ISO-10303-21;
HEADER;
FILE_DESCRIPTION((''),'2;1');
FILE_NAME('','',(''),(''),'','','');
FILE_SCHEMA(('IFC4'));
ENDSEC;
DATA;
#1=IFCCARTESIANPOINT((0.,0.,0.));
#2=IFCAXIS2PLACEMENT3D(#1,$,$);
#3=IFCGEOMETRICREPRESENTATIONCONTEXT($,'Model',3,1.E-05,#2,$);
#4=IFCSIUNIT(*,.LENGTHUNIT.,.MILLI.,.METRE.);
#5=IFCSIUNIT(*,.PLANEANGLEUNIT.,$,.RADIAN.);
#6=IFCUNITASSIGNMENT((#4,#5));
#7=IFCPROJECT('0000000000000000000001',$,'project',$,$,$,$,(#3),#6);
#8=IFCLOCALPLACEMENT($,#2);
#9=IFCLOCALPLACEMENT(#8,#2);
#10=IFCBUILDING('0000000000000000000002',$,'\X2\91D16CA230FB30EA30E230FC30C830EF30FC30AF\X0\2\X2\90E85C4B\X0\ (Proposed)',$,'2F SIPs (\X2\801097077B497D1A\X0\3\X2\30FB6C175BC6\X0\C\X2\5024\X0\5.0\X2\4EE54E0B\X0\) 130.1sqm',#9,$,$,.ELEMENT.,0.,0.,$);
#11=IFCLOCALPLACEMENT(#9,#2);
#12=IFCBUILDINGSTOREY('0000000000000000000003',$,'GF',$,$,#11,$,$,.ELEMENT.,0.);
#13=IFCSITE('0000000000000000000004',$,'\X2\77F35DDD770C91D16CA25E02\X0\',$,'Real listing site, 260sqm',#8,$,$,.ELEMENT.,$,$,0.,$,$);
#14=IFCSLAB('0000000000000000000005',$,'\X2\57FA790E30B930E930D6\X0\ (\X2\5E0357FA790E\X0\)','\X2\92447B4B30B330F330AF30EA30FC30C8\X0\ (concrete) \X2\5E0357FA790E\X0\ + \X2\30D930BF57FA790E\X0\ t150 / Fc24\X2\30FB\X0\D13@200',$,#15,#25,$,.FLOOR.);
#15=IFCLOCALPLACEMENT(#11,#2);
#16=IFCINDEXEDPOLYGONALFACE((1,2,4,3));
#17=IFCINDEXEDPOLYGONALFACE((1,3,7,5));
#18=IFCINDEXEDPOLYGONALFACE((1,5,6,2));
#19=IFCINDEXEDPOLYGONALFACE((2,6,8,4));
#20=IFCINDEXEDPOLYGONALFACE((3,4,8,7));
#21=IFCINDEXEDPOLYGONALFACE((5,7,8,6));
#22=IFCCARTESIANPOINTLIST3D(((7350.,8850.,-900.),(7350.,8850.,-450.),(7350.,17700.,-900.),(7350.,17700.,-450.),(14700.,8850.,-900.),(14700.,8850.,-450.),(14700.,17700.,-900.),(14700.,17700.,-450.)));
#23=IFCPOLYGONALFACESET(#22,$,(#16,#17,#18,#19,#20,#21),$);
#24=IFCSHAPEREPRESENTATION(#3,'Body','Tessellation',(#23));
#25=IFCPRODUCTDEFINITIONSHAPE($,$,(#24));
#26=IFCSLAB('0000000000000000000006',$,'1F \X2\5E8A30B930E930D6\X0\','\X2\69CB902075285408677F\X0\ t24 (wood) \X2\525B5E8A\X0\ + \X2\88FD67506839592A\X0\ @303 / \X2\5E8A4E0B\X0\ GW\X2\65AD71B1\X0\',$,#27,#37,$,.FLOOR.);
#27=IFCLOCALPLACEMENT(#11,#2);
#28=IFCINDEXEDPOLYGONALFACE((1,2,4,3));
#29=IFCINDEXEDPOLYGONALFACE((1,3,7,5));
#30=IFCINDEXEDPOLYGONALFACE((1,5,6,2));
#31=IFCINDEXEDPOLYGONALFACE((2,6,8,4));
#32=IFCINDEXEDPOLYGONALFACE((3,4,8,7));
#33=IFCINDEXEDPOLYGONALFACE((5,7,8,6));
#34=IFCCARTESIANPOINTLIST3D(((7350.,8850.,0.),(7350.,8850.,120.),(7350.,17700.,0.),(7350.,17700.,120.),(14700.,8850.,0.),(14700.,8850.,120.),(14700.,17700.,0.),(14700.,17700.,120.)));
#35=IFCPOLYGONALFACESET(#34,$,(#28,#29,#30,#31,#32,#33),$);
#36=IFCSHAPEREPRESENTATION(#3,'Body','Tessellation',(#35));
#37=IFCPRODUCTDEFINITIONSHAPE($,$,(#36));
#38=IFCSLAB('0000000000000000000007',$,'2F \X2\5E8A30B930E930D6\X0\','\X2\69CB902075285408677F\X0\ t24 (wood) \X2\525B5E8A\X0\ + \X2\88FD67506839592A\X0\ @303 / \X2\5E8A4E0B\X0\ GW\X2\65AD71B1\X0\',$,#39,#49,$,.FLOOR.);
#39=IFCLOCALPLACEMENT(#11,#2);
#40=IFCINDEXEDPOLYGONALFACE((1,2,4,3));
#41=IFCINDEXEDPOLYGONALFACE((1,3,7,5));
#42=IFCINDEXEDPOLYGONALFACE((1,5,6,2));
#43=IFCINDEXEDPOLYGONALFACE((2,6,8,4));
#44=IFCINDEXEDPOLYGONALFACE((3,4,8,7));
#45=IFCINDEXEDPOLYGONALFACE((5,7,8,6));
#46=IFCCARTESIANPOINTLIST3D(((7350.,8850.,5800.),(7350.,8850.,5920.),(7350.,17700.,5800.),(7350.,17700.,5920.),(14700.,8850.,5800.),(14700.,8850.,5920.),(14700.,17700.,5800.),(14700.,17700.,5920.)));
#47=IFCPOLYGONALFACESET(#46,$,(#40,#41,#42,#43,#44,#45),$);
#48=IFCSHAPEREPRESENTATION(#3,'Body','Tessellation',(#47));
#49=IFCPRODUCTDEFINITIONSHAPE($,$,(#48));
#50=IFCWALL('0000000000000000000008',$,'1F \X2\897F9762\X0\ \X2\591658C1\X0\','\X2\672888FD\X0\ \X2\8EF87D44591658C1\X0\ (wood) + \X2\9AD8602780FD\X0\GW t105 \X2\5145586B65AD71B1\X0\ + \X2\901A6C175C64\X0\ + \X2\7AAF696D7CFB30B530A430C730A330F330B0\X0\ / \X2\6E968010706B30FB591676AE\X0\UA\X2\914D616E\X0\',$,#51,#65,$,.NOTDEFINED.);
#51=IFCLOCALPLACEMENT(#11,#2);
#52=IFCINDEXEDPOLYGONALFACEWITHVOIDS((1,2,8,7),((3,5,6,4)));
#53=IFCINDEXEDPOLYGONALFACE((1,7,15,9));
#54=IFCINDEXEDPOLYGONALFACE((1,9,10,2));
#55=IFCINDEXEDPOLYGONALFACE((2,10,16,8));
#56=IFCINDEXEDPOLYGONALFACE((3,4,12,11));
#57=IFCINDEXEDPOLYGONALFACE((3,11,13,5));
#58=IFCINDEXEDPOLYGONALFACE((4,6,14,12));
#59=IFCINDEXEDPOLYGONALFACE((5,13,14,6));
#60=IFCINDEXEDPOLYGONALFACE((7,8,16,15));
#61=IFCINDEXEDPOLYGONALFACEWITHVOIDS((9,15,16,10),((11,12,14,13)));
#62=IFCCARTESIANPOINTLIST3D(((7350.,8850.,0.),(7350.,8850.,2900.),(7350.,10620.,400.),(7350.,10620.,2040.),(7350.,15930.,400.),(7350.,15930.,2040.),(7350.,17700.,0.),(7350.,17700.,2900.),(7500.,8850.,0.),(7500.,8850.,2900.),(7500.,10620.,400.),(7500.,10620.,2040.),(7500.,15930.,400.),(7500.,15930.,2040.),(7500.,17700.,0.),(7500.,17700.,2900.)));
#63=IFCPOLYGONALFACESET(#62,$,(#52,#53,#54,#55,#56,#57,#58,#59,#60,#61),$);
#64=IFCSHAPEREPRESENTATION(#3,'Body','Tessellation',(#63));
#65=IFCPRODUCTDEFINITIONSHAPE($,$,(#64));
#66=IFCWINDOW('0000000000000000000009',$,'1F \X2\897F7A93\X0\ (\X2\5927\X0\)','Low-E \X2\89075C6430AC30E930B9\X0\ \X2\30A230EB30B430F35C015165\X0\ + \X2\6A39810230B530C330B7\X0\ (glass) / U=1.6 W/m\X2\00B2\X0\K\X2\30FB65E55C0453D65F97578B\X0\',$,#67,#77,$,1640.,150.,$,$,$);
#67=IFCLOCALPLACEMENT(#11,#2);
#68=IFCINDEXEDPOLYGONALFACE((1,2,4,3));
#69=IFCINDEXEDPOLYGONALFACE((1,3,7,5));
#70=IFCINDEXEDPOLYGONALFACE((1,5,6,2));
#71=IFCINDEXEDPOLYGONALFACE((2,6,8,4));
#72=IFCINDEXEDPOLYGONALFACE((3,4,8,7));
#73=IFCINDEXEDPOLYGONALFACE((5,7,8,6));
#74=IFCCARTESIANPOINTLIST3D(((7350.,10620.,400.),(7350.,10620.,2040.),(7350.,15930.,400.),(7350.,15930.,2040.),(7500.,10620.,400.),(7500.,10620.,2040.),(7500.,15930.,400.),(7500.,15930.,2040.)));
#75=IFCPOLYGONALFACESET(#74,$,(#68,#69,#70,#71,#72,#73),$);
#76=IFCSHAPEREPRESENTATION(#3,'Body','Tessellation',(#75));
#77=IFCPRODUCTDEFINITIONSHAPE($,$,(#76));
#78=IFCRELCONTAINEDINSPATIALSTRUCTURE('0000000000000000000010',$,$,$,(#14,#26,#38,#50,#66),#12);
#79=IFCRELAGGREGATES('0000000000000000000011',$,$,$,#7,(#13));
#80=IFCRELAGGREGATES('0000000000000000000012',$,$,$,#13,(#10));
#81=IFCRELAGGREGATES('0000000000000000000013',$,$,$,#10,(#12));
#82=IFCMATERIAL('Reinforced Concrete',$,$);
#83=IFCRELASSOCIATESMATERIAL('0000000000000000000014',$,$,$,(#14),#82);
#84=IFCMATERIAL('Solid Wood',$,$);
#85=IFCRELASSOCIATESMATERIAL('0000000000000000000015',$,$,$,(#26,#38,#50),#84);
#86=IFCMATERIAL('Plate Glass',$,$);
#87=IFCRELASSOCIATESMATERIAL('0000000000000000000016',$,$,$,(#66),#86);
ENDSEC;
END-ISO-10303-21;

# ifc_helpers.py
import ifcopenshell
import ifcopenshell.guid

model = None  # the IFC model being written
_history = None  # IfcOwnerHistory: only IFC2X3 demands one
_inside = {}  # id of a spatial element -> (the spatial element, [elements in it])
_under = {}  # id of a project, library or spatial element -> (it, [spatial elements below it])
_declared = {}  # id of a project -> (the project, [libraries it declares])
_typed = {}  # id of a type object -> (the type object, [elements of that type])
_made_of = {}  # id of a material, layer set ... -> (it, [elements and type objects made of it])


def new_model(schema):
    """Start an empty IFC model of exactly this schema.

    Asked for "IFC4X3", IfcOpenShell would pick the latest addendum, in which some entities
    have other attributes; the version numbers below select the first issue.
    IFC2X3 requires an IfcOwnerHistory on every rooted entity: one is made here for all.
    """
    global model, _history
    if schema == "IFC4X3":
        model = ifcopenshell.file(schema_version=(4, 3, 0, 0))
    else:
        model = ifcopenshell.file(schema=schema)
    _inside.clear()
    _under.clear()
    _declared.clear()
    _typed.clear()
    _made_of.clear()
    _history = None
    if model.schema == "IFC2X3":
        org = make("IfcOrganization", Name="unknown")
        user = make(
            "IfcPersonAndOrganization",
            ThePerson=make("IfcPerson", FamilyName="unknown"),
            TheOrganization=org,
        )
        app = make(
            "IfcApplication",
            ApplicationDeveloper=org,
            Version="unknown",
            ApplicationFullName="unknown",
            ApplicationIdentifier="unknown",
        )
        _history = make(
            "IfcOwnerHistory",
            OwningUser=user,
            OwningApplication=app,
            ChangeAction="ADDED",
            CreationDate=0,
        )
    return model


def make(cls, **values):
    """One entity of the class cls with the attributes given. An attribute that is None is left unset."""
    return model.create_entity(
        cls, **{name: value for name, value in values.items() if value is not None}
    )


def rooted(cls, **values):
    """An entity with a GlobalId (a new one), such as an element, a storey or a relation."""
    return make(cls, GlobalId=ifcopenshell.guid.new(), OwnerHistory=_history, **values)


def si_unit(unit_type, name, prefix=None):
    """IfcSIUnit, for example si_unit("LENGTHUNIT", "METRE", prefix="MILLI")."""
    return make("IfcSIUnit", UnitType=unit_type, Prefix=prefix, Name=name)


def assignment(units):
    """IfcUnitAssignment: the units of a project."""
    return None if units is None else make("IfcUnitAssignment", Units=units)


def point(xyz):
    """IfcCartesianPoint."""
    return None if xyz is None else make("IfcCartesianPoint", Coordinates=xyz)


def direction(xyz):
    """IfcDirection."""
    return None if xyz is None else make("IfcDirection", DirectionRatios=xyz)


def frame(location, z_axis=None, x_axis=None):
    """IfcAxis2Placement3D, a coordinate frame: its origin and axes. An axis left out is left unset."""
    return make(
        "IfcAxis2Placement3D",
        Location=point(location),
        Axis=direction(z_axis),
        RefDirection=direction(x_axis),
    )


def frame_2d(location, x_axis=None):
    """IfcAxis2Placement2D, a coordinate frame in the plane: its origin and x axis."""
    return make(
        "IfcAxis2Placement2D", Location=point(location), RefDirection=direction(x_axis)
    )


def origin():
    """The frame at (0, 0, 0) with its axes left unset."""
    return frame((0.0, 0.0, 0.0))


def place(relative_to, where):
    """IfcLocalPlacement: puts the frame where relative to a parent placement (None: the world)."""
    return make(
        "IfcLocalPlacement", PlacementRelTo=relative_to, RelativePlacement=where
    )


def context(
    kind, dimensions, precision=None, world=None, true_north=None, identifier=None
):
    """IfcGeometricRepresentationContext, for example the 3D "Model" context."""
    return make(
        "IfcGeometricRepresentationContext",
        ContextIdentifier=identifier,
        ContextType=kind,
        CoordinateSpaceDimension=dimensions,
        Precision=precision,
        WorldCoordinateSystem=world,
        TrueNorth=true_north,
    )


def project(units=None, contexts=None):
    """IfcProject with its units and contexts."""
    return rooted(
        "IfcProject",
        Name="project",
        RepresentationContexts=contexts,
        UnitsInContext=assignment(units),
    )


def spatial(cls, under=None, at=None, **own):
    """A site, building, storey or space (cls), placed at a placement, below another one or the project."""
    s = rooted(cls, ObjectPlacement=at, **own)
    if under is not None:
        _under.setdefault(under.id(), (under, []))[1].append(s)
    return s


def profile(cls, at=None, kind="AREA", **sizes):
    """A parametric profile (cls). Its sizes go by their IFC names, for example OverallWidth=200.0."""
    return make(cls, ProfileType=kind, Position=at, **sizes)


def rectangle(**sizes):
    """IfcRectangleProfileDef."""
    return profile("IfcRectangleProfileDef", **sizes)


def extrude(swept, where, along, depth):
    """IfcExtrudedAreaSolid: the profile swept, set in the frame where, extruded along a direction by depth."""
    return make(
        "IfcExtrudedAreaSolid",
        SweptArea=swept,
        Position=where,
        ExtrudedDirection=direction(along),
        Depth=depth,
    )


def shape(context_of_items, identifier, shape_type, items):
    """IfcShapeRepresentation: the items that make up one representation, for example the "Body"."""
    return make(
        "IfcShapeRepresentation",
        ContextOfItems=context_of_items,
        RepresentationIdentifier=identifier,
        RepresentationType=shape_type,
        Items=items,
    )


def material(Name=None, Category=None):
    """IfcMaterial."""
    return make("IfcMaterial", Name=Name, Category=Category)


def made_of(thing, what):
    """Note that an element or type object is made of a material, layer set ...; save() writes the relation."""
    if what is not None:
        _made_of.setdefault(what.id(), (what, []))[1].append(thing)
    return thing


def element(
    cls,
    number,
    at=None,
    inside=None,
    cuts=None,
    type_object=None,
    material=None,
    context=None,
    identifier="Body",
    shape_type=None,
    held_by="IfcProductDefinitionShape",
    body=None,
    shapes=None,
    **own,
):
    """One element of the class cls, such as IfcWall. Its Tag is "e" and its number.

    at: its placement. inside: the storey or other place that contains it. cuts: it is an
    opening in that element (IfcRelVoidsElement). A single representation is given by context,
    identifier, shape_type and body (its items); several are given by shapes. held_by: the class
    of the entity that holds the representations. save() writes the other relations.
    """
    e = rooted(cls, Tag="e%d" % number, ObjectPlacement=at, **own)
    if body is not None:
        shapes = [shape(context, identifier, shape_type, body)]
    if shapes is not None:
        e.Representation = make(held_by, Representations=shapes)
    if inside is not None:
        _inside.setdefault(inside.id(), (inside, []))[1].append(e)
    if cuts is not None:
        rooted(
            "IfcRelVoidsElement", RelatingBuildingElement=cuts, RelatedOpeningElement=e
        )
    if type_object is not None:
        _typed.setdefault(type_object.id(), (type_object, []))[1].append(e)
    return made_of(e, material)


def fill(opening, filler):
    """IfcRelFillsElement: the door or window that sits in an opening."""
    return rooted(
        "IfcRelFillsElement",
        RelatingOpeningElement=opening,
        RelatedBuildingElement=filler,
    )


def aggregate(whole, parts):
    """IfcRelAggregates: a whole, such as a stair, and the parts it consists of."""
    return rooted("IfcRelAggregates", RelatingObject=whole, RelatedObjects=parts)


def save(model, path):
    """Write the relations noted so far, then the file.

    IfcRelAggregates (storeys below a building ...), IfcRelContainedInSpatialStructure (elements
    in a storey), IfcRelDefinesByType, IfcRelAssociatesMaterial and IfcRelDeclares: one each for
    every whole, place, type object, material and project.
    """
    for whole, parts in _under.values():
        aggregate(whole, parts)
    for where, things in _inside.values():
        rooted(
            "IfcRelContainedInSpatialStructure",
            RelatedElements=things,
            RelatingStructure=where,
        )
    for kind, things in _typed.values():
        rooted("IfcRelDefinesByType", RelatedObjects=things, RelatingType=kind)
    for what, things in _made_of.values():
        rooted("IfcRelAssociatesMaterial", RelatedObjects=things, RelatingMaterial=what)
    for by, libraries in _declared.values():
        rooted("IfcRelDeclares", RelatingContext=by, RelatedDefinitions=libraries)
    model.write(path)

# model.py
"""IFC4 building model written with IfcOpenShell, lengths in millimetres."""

from ifc_helpers import new_model, si_unit, frame, frame_2d, origin, place, context, project, spatial, rectangle, extrude, material, element, fill, save


model = new_model("IFC4")

# Units and contexts
model_context = context("Model", 3, precision=1e-05, world=origin())
ifc_project = project(units=[si_unit("LENGTHUNIT", "METRE", prefix="MILLI"), si_unit("PLANEANGLEUNIT", "RADIAN")], contexts=[model_context])

# Site, building, storey
site_placement = place(None, origin())
site = spatial("IfcSite", under=ifc_project, at=site_placement, Name="石川県金沢市", ObjectType="Real listing site, 260sqm", CompositionType="ELEMENT", RefElevation=0.0)
building_placement = place(site_placement, origin())
building = spatial("IfcBuilding", under=site, at=building_placement, Name="金沢・リモートワーク2部屋 (Proposed)", ObjectType="2F SIPs (耐震等級3・気密C値5.0以下) 130.1sqm", CompositionType="ELEMENT", ElevationOfRefHeight=0.0, ElevationOfTerrain=0.0)
storey_placement = place(building_placement, origin())
storey = spatial("IfcBuildingStorey", under=building, at=storey_placement, Name="GF", CompositionType="ELEMENT", Elevation=0.0)

# Shared definitions
ifc_material_1 = material(Name="Solid Wood")

# Slabs
ifc_material_2 = material(Name="Reinforced Concrete")
slab_1_placement = place(storey_placement, frame((3675.0, 4425.0, -450.0)))
element("IfcSlab", 1, at=slab_1_placement, inside=storey, material=ifc_material_2, Name="基礎スラブ (布基礎)", Description="鉄筋コンクリート (concrete) 布基礎 + ベタ基礎 t150 / Fc24・D13@200", PredefinedType="FLOOR", context=model_context, shape_type="SweptSolid", body=[
    extrude(rectangle(XDim=7350.0, YDim=8850.0, at=frame_2d((3675.0, 4425.0))), frame((3675.0, 4425.0, -450.0)), (0.0, 0.0, 1.0), 450.0),
])
slab_2_placement = place(storey_placement, frame((3675.0, 4425.0, 0.0)))
element("IfcSlab", 2, at=slab_2_placement, inside=storey, material=ifc_material_1, Name="1F 床スラブ", Description="構造用合板 t24 (wood) 剛床 + 製材根太 @303 / 床下 GW断熱", PredefinedType="FLOOR", context=model_context, shape_type="SweptSolid", body=[
    extrude(rectangle(XDim=7350.0, YDim=8850.0, at=frame_2d((3675.0, 4425.0))), frame((3675.0, 4425.0, 0.0)), (0.0, 0.0, 1.0), 120.0),
])
slab_3_placement = place(storey_placement, frame((3675.0, 4425.0, 2900.0)))
element("IfcSlab", 3, at=slab_3_placement, inside=storey, material=ifc_material_1, Name="2F 床スラブ", Description="構造用合板 t24 (wood) 剛床 + 製材根太 @303 / 床下 GW断熱", PredefinedType="FLOOR", context=model_context, shape_type="SweptSolid", body=[
    extrude(rectangle(XDim=7350.0, YDim=8850.0, at=frame_2d((3675.0, 4425.0))), frame((3675.0, 4425.0, 2900.0)), (0.0, 0.0, 1.0), 120.0),
])

# Shared definitions
ifc_material_3 = material(Name="Plate Glass")

# Wall, opening, window
wall_1_placement = place(storey_placement, frame((3675.0, 4425.0, 0.0)))
wall_1 = element("IfcWall", 4, at=wall_1_placement, inside=storey, material=ifc_material_1, Name="1F 西面 外壁", Description="木製 軸組外壁 (wood) + 高性能GW t105 充填断熱 + 通気層 + 窯業系サイディング / 準耐火・外皮UA配慮", PredefinedType="NOTDEFINED", context=model_context, shape_type="SweptSolid", body=[
    extrude(rectangle(XDim=150.0, YDim=8850.0, at=frame_2d((75.0, 4425.0))), frame((3675.0, 4425.0, 0.0)), (0.0, 0.0, 1.0), 2900.0),
])
opening_1_placement = place(storey_placement, frame((3675.0, 5310.0, 200.0)))
opening_1 = element("IfcOpeningElement", 5, at=opening_1_placement, cuts=wall_1, PredefinedType="NOTDEFINED", context=model_context, shape_type="SweptSolid", body=[
    extrude(rectangle(XDim=150.0, YDim=5310.0, at=frame_2d((75.0, 2655.0))), frame((3675.0, 5310.0, 200.0)), (0.0, 0.0, 1.0), 1640.0),
])
window_1_placement = place(storey_placement, frame((3675.0, 5310.0, 200.0)))
window_1 = element("IfcWindow", 6, at=window_1_placement, inside=storey, material=ifc_material_3, Name="1F 西窓 (大)", Description="Low-E 複層ガラス アルゴン封入 + 樹脂サッシ (glass) / U=1.6 W/m²K・日射取得型", OverallHeight=1640.0, OverallWidth=150.0, context=model_context, shape_type="SweptSolid", body=[
    extrude(rectangle(XDim=150.0, YDim=5310.0, at=frame_2d((75.0, 2655.0))), frame((3675.0, 5310.0, 200.0)), (0.0, 0.0, 1.0), 1640.0),
])
fill(opening_1, window_1)

save(model, "model.ifc")
